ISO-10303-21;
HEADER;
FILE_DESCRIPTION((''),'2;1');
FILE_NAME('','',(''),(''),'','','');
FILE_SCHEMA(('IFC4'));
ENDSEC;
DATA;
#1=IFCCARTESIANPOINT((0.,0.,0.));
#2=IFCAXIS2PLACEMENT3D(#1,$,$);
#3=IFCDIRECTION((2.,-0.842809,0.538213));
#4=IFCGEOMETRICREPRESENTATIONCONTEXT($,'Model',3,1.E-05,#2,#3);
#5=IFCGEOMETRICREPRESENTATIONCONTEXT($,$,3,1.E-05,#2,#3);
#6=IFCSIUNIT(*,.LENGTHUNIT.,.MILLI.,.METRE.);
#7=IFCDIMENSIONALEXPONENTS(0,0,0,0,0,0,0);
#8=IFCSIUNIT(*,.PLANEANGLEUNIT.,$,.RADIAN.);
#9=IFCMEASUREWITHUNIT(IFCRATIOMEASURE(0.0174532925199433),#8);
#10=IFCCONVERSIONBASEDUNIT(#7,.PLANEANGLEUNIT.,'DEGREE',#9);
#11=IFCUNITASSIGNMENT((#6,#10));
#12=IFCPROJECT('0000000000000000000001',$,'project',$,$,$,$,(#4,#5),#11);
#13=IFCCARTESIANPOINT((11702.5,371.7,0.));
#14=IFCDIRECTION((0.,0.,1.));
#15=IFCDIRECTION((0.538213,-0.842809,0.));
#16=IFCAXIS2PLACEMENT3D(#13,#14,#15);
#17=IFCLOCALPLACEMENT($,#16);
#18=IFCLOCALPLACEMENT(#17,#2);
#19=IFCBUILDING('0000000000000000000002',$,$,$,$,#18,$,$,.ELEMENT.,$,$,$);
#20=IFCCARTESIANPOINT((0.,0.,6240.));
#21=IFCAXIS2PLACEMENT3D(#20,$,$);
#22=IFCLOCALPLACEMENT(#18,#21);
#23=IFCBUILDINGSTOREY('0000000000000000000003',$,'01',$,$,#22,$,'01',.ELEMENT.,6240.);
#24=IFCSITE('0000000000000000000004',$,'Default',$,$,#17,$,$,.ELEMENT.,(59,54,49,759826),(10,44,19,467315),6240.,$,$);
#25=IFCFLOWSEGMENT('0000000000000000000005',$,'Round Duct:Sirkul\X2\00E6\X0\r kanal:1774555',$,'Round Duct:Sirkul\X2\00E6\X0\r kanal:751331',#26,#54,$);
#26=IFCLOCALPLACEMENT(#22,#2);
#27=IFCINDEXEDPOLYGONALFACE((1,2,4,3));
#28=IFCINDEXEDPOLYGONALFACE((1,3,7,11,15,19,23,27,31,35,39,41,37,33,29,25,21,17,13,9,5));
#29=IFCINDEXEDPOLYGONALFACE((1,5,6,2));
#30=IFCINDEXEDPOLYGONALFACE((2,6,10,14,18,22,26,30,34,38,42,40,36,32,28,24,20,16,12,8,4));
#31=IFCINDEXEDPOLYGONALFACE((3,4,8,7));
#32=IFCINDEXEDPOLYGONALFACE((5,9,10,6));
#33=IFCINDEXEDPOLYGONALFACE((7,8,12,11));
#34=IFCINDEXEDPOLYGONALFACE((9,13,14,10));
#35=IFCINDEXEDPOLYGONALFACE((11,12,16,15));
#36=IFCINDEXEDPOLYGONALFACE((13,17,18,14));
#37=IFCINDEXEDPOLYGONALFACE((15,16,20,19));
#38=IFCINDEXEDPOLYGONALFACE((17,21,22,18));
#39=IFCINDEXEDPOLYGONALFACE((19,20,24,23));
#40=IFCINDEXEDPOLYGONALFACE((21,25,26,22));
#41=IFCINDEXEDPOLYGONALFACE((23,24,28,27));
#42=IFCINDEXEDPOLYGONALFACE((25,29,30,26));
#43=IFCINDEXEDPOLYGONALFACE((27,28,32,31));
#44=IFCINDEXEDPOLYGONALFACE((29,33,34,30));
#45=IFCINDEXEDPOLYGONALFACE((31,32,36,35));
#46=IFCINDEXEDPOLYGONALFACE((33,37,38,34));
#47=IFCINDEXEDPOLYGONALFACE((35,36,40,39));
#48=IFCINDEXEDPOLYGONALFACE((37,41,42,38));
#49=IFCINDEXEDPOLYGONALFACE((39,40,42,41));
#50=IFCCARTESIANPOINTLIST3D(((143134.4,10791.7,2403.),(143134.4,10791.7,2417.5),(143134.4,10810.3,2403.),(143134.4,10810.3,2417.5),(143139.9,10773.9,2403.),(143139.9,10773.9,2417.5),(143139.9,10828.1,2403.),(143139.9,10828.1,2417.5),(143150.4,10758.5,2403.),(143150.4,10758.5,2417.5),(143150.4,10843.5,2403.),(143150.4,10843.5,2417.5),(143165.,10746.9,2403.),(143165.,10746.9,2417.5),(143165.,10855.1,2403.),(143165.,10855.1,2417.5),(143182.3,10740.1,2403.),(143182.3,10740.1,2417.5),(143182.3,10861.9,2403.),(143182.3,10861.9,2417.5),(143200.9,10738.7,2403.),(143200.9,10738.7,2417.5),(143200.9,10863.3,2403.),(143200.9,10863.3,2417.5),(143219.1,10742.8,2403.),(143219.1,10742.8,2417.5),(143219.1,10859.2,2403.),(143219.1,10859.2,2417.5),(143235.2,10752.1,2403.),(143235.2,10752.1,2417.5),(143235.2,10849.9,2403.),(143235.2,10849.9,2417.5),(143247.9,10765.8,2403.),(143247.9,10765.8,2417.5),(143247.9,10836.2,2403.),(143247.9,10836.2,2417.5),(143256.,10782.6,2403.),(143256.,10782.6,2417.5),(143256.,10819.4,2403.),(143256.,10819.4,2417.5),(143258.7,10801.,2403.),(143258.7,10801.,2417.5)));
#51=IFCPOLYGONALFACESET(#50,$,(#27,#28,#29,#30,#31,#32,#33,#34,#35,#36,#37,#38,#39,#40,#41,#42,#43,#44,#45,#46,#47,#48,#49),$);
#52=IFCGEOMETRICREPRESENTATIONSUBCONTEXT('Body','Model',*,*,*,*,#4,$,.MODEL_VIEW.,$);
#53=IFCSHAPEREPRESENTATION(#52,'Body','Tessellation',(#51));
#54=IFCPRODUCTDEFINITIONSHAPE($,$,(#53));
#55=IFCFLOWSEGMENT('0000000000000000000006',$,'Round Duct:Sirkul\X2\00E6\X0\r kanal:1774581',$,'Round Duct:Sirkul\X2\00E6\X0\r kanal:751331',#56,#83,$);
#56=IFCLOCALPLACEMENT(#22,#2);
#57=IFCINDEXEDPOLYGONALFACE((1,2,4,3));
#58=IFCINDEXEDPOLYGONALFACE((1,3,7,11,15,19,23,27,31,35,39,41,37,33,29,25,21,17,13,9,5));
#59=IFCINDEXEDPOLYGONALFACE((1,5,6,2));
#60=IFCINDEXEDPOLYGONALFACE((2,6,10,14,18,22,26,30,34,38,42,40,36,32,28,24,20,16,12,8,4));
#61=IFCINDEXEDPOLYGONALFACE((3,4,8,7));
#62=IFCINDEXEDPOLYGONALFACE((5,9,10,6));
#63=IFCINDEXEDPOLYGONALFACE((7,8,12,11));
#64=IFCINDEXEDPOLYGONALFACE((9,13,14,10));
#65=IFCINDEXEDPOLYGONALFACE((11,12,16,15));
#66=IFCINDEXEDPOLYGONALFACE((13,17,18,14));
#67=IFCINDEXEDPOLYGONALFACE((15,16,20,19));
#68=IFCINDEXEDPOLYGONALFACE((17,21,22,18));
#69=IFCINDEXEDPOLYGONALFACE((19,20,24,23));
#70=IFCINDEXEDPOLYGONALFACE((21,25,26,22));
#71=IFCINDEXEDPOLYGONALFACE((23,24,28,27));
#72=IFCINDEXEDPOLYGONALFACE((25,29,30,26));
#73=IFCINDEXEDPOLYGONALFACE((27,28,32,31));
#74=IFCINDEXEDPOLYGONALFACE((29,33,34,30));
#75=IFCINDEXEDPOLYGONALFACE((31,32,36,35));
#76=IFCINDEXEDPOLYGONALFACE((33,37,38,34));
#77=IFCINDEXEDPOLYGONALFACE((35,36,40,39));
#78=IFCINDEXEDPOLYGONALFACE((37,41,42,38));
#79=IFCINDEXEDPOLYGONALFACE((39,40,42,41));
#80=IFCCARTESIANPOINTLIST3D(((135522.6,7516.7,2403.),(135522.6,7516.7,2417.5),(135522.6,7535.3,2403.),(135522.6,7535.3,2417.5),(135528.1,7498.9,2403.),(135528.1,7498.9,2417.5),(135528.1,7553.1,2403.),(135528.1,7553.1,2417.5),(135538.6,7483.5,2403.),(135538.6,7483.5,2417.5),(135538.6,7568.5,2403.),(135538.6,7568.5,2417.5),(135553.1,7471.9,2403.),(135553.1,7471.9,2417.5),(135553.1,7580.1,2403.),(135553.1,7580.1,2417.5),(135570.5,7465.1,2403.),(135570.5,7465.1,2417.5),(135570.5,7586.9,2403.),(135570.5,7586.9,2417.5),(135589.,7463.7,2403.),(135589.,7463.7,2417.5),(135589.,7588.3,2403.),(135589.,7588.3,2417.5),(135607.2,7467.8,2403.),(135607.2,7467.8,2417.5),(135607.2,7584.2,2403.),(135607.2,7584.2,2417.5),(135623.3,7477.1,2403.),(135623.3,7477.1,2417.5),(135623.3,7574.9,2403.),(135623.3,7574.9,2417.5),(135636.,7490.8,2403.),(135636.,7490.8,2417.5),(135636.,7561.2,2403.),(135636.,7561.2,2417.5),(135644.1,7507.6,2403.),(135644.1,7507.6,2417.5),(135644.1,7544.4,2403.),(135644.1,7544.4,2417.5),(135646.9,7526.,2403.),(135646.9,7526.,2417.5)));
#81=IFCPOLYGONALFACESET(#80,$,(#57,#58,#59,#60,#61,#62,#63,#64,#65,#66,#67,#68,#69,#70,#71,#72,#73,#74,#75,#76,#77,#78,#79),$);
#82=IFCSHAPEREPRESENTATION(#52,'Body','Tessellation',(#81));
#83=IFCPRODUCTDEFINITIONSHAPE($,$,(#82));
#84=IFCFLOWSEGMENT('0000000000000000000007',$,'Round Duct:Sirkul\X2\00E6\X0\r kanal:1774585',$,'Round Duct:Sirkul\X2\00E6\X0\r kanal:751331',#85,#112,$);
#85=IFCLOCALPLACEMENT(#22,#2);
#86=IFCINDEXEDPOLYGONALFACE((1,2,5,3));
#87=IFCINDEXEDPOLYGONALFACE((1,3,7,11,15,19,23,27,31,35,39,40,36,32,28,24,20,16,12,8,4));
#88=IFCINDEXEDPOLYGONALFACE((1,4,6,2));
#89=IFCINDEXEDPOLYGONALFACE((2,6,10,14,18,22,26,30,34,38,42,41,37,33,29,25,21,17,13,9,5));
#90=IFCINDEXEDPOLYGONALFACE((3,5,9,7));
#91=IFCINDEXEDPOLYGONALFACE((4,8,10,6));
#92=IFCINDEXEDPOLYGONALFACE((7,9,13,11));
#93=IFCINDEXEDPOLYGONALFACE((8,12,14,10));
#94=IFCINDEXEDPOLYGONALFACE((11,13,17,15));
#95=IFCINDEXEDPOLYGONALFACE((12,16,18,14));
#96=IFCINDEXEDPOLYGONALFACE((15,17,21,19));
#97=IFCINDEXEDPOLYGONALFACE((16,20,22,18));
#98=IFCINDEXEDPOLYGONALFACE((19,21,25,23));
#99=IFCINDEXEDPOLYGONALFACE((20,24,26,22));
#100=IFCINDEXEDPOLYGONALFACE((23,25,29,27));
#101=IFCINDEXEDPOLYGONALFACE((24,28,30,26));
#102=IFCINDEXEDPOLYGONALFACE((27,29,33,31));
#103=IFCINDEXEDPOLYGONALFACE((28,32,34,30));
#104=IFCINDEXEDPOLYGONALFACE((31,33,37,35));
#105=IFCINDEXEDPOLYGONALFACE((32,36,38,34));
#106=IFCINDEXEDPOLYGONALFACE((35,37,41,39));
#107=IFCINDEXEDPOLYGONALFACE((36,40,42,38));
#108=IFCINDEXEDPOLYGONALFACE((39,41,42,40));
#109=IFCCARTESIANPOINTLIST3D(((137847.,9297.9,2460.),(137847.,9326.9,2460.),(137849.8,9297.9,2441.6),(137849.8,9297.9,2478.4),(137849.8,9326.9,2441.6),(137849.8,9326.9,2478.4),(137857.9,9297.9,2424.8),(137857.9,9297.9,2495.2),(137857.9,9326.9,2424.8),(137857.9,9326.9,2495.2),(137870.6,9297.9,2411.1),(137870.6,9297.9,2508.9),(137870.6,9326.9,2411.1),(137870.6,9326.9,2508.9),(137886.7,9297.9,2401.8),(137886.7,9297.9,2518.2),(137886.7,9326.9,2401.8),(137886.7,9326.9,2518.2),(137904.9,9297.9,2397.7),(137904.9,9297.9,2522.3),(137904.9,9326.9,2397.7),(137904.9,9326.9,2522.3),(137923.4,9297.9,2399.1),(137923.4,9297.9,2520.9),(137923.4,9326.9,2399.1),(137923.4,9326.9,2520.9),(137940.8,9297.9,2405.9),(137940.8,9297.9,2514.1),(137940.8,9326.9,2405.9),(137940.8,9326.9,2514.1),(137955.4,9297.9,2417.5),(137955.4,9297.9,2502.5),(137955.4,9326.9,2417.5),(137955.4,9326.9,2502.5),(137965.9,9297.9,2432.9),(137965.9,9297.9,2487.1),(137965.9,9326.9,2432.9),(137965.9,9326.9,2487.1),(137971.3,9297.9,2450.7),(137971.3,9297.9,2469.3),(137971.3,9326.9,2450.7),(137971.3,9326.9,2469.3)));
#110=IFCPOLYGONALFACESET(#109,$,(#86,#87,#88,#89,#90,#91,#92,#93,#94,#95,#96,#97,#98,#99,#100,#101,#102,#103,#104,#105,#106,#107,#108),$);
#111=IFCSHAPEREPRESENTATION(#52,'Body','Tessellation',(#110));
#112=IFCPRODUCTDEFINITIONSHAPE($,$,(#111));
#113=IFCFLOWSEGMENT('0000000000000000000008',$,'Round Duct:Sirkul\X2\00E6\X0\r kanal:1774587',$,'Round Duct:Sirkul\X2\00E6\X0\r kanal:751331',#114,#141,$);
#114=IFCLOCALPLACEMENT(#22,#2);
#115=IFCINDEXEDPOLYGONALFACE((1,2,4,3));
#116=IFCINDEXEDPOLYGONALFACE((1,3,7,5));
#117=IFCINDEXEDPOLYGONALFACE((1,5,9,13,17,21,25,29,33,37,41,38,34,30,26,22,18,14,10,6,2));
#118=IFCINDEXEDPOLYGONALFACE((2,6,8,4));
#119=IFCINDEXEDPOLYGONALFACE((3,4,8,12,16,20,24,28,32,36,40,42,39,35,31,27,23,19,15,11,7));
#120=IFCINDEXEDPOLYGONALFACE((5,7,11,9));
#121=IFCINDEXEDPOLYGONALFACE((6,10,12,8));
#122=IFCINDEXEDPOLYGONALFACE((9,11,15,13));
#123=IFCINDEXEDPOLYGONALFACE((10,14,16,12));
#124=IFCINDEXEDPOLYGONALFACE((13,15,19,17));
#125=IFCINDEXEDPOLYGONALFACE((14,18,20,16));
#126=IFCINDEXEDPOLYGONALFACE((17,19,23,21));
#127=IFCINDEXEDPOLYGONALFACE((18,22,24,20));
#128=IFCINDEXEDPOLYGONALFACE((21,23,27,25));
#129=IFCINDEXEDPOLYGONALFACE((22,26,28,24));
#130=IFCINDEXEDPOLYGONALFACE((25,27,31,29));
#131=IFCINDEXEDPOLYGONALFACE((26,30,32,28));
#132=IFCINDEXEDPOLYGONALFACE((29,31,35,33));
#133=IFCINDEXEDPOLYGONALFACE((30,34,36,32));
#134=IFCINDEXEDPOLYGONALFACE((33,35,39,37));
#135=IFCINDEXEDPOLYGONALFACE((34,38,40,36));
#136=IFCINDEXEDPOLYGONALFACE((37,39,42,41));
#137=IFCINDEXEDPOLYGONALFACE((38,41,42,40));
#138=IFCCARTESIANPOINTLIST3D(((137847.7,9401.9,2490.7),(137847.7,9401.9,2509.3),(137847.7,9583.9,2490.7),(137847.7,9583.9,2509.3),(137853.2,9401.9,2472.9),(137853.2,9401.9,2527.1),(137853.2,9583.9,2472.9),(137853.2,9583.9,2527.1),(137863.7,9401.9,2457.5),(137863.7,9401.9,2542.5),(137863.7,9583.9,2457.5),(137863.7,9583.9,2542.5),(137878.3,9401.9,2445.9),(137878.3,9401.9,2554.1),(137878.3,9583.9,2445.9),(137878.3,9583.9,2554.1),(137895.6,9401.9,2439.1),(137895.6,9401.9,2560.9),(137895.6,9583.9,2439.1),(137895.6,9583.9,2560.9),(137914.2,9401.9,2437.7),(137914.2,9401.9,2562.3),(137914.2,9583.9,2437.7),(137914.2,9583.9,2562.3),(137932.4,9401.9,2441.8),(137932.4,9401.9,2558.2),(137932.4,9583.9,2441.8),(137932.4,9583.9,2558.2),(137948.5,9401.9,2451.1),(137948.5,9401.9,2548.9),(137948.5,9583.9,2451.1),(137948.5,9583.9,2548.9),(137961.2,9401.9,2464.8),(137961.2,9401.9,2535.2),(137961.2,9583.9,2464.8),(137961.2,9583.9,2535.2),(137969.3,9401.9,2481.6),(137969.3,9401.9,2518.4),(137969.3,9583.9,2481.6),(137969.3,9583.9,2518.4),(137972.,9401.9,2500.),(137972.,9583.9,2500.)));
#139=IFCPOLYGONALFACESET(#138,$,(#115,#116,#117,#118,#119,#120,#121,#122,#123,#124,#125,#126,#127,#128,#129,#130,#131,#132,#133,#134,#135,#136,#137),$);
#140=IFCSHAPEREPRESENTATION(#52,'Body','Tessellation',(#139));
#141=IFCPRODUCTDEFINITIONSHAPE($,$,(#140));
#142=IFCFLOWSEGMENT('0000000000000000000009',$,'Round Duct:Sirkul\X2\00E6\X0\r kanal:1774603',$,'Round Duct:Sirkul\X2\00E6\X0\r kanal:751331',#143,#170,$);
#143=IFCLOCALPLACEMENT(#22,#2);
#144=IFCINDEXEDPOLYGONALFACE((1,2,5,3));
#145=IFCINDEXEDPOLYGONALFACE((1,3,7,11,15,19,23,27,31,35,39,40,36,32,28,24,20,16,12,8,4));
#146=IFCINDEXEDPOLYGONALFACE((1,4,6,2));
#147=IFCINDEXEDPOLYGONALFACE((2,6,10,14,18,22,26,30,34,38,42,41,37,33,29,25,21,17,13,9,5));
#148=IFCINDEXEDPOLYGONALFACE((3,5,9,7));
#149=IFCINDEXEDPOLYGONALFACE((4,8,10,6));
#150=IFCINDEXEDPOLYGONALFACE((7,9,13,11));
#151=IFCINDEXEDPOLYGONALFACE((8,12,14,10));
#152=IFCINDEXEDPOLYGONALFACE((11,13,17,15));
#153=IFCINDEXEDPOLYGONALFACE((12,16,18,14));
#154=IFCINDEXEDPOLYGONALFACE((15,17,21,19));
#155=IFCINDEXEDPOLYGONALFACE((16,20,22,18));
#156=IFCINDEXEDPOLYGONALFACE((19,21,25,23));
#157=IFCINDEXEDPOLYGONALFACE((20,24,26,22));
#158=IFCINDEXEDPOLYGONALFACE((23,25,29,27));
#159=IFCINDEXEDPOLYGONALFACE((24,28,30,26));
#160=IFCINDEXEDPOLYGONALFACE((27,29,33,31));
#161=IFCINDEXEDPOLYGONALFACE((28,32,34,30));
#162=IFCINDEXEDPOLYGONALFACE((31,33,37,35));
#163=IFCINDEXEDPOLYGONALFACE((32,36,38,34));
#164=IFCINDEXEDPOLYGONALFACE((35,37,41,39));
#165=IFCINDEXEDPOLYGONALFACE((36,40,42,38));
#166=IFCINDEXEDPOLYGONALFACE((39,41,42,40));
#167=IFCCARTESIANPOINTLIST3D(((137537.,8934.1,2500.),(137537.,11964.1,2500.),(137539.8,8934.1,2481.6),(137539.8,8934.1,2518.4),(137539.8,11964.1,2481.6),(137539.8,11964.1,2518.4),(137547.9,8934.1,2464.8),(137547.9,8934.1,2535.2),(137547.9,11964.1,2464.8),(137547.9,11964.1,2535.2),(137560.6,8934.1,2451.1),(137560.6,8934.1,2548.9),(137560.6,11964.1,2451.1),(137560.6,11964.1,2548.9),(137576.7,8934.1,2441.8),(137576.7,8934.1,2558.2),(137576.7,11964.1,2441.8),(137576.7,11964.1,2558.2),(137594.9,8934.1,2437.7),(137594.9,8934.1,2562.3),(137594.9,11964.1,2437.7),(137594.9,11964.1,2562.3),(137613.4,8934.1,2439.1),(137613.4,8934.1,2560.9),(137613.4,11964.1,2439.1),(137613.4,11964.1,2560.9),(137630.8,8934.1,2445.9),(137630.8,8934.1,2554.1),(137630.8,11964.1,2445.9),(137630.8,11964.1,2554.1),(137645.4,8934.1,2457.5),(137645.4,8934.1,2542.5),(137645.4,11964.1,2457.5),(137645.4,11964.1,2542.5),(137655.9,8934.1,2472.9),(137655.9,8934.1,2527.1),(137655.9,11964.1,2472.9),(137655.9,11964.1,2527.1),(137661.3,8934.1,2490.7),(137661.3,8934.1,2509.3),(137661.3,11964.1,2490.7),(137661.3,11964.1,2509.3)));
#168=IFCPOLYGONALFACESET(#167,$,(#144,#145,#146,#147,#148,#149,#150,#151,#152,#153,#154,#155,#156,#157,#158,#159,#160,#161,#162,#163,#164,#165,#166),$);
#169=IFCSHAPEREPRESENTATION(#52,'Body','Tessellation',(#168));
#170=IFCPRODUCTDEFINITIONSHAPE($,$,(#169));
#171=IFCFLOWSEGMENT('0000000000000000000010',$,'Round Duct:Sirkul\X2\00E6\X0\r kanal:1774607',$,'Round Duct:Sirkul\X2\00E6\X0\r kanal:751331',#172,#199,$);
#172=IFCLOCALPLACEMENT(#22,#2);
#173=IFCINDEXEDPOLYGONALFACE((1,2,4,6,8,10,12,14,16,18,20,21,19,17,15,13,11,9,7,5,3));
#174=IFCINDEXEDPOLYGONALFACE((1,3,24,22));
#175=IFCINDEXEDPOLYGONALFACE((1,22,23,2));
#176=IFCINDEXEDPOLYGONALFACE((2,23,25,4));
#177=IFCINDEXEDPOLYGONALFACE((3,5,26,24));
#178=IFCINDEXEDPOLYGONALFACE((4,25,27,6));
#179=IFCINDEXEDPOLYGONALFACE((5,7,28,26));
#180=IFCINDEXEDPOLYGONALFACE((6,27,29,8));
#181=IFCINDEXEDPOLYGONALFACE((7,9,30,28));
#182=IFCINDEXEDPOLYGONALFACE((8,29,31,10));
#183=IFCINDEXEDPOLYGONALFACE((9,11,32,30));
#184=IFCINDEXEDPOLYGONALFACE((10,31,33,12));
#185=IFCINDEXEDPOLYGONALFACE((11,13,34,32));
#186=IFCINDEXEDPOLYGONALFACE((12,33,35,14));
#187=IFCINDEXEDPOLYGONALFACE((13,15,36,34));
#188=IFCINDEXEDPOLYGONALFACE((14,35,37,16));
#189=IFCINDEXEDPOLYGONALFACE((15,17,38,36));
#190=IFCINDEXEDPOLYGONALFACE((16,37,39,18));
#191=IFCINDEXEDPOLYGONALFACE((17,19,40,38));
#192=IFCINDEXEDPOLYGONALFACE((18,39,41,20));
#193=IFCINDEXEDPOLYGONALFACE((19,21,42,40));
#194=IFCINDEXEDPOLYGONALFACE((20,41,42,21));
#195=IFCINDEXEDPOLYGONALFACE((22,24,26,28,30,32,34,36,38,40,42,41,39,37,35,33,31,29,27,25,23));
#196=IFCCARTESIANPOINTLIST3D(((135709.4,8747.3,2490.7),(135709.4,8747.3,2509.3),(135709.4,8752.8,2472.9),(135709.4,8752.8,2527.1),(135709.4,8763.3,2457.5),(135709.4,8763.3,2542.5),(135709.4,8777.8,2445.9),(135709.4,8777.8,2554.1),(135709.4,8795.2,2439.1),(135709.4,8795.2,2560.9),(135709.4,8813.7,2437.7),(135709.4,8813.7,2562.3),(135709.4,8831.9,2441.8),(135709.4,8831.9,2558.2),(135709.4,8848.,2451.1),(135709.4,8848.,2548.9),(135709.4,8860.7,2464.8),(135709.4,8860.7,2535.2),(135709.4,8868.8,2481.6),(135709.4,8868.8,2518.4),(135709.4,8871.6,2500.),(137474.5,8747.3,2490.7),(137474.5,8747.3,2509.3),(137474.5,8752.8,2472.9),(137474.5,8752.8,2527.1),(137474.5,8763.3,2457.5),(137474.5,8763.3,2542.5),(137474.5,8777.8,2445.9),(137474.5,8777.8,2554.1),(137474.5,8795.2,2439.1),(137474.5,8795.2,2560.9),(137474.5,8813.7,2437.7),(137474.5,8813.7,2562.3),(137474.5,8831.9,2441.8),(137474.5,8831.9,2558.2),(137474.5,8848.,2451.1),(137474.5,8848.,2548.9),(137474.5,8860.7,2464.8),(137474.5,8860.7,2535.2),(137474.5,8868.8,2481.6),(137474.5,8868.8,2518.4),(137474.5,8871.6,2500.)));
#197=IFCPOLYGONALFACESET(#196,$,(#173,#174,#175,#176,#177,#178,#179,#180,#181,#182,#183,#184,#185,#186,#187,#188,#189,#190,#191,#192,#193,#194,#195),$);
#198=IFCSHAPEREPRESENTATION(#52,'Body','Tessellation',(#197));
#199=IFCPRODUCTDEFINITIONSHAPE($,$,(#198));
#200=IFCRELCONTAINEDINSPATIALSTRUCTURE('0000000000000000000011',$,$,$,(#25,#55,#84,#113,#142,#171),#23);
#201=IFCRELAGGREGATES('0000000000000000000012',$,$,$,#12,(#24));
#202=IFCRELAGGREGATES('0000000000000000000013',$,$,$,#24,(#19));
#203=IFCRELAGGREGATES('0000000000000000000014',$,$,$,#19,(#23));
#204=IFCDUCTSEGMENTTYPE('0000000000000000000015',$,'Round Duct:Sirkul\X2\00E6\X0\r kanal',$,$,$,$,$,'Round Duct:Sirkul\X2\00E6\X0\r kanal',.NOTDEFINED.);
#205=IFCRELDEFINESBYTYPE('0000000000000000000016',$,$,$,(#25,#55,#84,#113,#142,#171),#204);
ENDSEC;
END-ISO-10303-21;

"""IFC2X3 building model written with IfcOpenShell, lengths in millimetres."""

from ifc_helpers import new_model, entity, si_unit, converted_unit, direction, frame, frame_2d, origin, origin_2d_with_axis, place, context, subcontext, project, spatial, circle, extrude, type_object, element, save


model = new_model("IFC2X3")

# Units and contexts
model_context = context("Model", 3, precision=1e-05, world=origin(), true_north=direction((2.0, -0.842809, 0.538213)))
context_of_model = context(None, 3, precision=1e-05, world=origin(), true_north=direction((2.0, -0.842809, 0.538213)))
body_context = subcontext(model_context, "Body", "Model", "MODEL_VIEW")
ifc_project = project(units=[si_unit("LENGTHUNIT", "METRE", prefix="MILLI"), converted_unit("PLANEANGLEUNIT", "DEGREE", entity("IfcRatioMeasure", 0.0174532925199433), si_unit("PLANEANGLEUNIT", "RADIAN"), dimensions=[0, 0, 0, 0, 0, 0, 0])], contexts=[model_context, context_of_model])

# Site, building, storey
site_placement = place(None, frame((11702.5, 371.7, 0.0), z_axis=(0.0, 0.0, 1.0), x_axis=(0.538213, -0.842809, 0.0)))
site = spatial("IfcSite", under=ifc_project, at=site_placement, Name="Default", CompositionType="ELEMENT", RefLatitude=(59, 54, 49, 759826), RefLongitude=(10, 44, 19, 467315), RefElevation=6240.0)
building_placement = place(site_placement, origin())
building = spatial("IfcBuilding", under=site, at=building_placement, CompositionType="ELEMENT")
storey_placement = place(building_placement, frame((0.0, 0.0, 6240.0)))
storey = spatial("IfcBuildingStorey", under=building, at=storey_placement, Name="01", LongName="01", CompositionType="ELEMENT", Elevation=6240.0)

# Flow segments
duct_segment_type = type_object("IfcDuctSegmentType", Name="Round Duct:Sirkulær kanal", ElementType="Round Duct:Sirkulær kanal", PredefinedType="NOTDEFINED")
flow_segment_1_placement = place(storey_placement, origin())
element("IfcFlowSegment", 1, at=flow_segment_1_placement, inside=storey, type_object=duct_segment_type, Name="Round Duct:Sirkulær kanal:1774555", ObjectType="Round Duct:Sirkulær kanal:751331", context=body_context, shape_type="SweptSolid", body=[
    extrude(circle(Radius=62.5, at=frame_2d((0.0, 0.0), x_axis=(1.0, 0.0))), frame((143196.2, 10801.0, 2403.0)), (0.0, 0.0, 1.0), 14.5),
])
flow_segment_2_placement = place(storey_placement, origin())
element("IfcFlowSegment", 2, at=flow_segment_2_placement, inside=storey, type_object=duct_segment_type, Name="Round Duct:Sirkulær kanal:1774581", ObjectType="Round Duct:Sirkulær kanal:751331", context=body_context, shape_type="SweptSolid", body=[
    extrude(circle(Radius=62.5, at=frame_2d((0.0, 0.0), x_axis=(1.0, 0.0))), frame((135584.4, 7526.0, 2403.0)), (0.0, 0.0, 1.0), 14.5),
])
flow_segment_3_placement = place(storey_placement, origin())
element("IfcFlowSegment", 3, at=flow_segment_3_placement, inside=storey, type_object=duct_segment_type, Name="Round Duct:Sirkulær kanal:1774585", ObjectType="Round Duct:Sirkulær kanal:751331", context=body_context, shape_type="SweptSolid", body=[
    extrude(circle(Radius=62.5, at=frame_2d((0.0, 0.0), x_axis=(1.0, 0.0))), frame((137909.5, 9297.9, 2460.0), z_axis=(0.0, 1.0, 0.0), x_axis=(-1.0, 0.0, 0.0)), (0.0, 0.0, 1.0), 29.0),
])
flow_segment_4_placement = place(storey_placement, origin())
element("IfcFlowSegment", 4, at=flow_segment_4_placement, inside=storey, type_object=duct_segment_type, Name="Round Duct:Sirkulær kanal:1774587", ObjectType="Round Duct:Sirkulær kanal:751331", context=body_context, shape_type="SweptSolid", body=[
    extrude(circle(Radius=62.5, at=frame_2d((0.0, 0.0), x_axis=(1.0, 0.0))), frame((137909.5, 9401.9, 2500.0), z_axis=(0.0, 1.0, 0.0), x_axis=(1.0, 0.0, 0.0)), (0.0, 0.0, 1.0), 182.0),
])
flow_segment_5_placement = place(storey_placement, origin())
element("IfcFlowSegment", 5, at=flow_segment_5_placement, inside=storey, type_object=duct_segment_type, Name="Round Duct:Sirkulær kanal:1774603", ObjectType="Round Duct:Sirkulær kanal:751331", context=body_context, shape_type="SweptSolid", body=[
    extrude(circle(Radius=62.5, at=origin_2d_with_axis()), frame((137599.5, 8934.1, 2500.0), z_axis=(0.0, 1.0, 0.0), x_axis=(-1.0, 0.0, 0.0)), (0.0, 0.0, 1.0), 3030.0),
])
flow_segment_6_placement = place(storey_placement, origin())
element("IfcFlowSegment", 6, at=flow_segment_6_placement, inside=storey, type_object=duct_segment_type, Name="Round Duct:Sirkulær kanal:1774607", ObjectType="Round Duct:Sirkulær kanal:751331", context=body_context, shape_type="SweptSolid", body=[
    extrude(circle(Radius=62.5, at=frame_2d((0.0, 0.0), x_axis=(1.0, 0.0))), frame((135709.4, 8809.1, 2500.0), z_axis=(1.0, 0.0, 0.0), x_axis=(0.0, 1.0, 0.0)), (0.0, 0.0, 1.0), 1765.2),
])

save(model, "model.ifc")
